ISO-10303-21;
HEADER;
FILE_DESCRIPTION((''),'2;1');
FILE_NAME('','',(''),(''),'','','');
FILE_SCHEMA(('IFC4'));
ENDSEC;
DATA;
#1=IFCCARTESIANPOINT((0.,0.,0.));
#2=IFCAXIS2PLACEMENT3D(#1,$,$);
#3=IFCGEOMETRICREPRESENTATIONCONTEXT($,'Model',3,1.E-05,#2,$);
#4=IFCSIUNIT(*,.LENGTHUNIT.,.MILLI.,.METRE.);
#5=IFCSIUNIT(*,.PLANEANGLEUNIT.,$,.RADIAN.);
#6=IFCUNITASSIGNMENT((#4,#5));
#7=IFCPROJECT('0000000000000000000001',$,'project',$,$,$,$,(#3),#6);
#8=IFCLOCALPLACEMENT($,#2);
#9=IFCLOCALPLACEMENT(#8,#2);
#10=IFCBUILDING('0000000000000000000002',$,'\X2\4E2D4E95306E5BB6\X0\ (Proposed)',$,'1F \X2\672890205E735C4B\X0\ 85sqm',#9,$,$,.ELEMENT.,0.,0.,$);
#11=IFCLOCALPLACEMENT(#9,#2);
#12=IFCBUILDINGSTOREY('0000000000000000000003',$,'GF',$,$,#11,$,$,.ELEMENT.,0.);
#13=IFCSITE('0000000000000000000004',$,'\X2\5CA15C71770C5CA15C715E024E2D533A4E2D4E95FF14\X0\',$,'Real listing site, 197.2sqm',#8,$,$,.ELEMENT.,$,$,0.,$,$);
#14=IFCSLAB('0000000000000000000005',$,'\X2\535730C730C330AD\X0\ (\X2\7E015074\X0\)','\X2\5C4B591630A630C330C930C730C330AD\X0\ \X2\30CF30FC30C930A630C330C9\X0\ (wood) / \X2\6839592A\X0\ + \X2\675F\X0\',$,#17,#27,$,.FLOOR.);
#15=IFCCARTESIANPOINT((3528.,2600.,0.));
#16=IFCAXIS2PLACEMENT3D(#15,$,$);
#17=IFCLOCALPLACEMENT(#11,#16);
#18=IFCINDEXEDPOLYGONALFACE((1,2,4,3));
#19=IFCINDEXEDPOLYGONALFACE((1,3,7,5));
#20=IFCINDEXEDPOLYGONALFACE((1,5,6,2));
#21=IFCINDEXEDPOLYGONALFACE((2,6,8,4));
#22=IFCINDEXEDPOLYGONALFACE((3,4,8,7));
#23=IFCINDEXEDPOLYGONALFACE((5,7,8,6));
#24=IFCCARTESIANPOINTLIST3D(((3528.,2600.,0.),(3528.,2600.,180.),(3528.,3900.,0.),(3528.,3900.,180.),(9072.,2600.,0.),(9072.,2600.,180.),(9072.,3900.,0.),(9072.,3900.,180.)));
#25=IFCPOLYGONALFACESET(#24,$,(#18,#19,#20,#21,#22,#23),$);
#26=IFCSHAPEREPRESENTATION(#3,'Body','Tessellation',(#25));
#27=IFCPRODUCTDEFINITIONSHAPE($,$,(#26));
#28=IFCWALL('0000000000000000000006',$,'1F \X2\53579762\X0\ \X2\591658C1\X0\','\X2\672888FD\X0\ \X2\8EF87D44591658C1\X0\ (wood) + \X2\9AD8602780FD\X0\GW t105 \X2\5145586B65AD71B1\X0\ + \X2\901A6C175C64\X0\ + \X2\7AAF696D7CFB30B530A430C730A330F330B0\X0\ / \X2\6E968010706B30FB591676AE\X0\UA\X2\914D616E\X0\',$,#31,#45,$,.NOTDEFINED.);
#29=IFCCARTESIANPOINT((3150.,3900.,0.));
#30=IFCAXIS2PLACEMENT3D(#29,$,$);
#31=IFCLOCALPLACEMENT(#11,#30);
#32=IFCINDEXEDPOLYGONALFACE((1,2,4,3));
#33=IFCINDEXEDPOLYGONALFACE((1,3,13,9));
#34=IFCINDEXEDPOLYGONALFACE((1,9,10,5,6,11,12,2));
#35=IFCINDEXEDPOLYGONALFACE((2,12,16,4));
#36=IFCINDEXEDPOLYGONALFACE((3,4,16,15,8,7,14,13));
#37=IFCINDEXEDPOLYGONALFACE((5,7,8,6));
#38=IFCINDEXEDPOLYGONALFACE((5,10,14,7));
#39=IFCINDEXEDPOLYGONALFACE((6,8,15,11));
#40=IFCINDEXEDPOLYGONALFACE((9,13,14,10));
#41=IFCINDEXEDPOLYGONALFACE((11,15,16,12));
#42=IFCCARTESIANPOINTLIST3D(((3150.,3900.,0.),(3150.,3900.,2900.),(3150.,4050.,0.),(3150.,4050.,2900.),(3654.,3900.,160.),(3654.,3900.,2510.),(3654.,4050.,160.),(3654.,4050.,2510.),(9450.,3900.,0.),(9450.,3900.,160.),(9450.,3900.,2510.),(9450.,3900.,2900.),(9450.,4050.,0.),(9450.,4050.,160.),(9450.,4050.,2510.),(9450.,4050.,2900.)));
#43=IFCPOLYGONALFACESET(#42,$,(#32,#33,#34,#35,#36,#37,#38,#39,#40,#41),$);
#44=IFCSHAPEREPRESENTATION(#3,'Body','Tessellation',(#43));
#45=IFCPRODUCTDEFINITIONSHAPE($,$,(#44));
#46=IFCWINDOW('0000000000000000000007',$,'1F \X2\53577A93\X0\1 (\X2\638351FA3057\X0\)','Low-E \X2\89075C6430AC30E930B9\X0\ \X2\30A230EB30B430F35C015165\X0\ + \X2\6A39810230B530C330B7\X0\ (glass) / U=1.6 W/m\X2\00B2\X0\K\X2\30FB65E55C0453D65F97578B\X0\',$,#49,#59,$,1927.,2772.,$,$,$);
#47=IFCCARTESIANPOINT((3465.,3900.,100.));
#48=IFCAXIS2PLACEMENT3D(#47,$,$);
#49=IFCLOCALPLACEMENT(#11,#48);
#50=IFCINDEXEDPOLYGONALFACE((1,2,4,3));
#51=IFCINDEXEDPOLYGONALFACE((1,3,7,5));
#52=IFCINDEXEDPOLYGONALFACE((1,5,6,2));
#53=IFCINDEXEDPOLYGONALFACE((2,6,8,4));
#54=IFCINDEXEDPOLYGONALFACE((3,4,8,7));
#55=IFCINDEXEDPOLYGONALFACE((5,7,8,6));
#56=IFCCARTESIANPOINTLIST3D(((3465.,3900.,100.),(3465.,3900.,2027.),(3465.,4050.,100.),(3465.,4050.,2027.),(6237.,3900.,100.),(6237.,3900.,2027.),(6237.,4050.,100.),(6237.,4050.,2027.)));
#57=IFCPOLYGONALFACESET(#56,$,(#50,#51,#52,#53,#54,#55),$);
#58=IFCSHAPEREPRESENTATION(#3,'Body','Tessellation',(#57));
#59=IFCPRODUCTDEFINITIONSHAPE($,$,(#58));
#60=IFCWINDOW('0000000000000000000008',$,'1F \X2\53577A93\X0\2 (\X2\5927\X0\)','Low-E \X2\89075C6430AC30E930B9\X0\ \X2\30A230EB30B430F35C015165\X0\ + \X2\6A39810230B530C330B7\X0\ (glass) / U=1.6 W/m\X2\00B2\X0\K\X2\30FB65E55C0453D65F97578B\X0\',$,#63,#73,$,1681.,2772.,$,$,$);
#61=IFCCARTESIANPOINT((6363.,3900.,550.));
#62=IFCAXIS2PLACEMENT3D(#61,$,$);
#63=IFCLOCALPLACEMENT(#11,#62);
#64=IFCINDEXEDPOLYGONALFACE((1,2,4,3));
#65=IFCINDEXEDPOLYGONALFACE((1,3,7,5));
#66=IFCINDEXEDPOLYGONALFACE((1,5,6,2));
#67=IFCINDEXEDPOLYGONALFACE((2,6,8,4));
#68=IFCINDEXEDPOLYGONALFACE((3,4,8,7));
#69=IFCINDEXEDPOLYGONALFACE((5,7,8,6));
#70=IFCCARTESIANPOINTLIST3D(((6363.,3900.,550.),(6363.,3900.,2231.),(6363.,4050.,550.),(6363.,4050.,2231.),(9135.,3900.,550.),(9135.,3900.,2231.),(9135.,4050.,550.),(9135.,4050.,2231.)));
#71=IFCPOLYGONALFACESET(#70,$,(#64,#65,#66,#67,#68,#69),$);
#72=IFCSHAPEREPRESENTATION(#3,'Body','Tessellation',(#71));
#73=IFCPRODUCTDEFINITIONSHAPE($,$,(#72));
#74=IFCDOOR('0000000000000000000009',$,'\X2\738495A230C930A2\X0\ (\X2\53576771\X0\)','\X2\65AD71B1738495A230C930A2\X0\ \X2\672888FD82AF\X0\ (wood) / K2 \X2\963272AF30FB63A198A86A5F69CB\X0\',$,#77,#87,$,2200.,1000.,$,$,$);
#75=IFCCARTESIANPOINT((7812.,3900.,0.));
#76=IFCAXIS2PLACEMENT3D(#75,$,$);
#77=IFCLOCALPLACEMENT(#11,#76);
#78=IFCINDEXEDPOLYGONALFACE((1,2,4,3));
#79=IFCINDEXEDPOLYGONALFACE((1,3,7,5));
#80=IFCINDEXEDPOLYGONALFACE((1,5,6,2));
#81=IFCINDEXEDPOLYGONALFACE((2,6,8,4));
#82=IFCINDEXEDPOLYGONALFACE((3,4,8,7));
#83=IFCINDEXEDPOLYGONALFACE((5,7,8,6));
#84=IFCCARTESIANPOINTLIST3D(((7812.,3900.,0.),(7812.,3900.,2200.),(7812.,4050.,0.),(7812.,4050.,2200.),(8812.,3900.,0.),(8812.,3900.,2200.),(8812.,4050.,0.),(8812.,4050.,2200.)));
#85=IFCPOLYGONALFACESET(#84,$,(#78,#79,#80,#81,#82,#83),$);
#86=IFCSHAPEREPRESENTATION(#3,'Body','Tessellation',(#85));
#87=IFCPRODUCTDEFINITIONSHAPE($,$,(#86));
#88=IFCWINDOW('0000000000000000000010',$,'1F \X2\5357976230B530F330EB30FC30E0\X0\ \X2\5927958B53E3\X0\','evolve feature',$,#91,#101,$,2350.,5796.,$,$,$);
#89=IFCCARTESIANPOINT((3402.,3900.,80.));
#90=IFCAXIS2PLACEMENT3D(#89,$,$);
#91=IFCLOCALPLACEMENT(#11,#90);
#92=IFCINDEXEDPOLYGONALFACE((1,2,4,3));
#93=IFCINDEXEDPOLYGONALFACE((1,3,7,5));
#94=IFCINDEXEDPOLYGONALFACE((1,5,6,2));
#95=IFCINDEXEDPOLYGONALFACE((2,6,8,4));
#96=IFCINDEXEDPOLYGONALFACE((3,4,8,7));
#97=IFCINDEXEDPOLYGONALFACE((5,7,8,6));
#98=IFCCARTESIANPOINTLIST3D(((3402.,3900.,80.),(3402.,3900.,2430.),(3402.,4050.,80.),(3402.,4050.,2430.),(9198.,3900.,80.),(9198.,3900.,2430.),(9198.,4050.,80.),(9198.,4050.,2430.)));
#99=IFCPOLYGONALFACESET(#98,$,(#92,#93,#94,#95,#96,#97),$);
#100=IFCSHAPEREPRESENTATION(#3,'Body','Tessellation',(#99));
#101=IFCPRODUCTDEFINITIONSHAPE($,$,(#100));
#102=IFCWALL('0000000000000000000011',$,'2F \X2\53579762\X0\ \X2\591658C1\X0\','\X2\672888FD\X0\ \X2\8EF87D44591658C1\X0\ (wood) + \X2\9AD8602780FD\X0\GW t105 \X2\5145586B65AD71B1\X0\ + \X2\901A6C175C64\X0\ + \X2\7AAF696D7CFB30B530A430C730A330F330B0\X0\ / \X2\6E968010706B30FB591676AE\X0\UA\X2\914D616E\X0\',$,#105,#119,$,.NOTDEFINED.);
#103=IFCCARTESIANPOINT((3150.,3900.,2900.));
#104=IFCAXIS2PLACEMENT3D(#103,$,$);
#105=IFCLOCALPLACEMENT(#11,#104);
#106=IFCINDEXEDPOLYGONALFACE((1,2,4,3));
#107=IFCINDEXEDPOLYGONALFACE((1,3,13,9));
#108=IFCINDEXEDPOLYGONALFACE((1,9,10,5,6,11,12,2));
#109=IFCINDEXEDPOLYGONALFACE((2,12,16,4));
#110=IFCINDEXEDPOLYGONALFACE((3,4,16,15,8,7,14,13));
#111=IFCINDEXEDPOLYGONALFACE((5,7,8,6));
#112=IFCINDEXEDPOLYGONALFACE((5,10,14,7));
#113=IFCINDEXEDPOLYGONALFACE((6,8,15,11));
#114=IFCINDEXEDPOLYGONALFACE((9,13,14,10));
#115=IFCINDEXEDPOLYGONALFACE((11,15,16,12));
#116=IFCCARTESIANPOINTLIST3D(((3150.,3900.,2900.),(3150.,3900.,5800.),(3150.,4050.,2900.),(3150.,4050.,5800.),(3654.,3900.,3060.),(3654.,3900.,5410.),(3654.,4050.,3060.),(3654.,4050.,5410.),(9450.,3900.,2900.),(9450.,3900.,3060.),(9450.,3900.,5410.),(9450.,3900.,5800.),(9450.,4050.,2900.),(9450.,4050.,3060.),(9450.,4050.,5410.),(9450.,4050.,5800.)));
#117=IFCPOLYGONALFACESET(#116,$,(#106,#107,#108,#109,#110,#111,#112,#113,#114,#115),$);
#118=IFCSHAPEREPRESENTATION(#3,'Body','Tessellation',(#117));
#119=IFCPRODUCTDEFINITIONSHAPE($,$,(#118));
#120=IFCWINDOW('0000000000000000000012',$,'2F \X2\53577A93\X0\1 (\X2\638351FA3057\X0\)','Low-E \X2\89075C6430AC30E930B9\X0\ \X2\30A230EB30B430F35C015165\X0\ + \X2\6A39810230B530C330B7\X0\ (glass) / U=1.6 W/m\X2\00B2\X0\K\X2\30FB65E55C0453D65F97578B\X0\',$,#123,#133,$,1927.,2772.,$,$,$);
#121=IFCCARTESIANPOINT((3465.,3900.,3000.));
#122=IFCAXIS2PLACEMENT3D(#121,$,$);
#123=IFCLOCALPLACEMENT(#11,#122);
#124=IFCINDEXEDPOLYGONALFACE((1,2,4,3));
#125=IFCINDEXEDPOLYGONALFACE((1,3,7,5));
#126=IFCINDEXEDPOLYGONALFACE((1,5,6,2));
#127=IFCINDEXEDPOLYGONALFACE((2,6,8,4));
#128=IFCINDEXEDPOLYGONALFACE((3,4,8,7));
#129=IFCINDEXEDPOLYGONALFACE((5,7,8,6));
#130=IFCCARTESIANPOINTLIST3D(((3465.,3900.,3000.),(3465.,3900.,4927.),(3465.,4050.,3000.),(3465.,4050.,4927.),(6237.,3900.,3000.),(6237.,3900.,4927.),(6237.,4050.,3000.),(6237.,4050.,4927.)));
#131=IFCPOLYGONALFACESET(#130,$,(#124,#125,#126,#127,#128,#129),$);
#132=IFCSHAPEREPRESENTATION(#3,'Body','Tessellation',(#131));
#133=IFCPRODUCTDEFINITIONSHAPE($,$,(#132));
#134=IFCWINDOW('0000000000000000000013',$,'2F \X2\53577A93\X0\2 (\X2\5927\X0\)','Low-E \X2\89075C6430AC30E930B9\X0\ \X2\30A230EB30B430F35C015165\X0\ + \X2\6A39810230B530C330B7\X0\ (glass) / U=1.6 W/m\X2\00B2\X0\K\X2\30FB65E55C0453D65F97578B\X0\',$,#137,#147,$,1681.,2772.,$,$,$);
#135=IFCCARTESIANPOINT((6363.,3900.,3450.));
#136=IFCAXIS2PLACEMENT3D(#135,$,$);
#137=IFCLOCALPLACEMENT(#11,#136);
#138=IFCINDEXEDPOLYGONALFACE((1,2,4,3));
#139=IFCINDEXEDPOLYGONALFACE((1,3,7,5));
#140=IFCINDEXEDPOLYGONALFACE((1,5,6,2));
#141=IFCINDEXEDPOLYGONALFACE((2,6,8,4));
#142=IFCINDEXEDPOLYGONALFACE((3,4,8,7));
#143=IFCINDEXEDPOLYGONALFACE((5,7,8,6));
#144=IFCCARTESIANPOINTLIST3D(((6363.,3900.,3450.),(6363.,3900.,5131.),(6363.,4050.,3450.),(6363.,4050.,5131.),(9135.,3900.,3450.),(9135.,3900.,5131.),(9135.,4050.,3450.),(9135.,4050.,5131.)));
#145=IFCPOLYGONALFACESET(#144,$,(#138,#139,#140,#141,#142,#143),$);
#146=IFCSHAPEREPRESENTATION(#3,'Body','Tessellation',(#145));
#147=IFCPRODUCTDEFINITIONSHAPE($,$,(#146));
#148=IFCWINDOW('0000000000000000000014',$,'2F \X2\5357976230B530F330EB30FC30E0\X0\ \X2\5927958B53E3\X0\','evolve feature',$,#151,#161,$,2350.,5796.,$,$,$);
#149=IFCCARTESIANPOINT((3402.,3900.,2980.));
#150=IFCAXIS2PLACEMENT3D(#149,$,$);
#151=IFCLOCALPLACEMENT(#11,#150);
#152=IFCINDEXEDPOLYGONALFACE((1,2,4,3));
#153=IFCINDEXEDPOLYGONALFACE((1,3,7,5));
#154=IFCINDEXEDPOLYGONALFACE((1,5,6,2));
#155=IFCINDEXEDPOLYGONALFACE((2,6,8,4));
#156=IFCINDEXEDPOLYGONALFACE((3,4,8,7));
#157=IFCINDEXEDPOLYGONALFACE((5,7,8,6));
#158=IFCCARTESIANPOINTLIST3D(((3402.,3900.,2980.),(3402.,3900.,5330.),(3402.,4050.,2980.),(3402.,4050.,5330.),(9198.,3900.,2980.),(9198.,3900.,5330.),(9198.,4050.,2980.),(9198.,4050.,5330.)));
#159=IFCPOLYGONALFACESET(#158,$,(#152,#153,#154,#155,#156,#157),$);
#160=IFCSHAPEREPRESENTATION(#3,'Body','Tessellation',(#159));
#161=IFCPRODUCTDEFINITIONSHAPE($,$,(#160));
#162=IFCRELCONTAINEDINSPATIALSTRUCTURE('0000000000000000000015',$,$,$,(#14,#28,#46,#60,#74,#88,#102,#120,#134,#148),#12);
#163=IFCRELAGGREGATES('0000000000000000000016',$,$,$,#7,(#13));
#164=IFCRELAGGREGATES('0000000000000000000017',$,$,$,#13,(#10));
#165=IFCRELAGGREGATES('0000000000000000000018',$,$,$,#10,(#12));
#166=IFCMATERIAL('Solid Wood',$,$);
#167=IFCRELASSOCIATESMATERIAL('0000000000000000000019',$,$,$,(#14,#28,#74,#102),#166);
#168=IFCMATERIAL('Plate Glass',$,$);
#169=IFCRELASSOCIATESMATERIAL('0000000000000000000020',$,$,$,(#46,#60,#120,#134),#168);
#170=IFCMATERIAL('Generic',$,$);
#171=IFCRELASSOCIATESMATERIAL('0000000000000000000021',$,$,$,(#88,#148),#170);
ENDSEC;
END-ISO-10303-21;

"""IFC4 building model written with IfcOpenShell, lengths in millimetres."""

from ifc_helpers import new_model, si_unit, frame, frame_2d, origin, place, context, project, spatial, rectangle, extrude, material, element, fill, save


model = new_model("IFC4")

# Units and contexts
model_context = context("Model", 3, precision=1e-05, world=origin())
ifc_project = project(units=[si_unit("LENGTHUNIT", "METRE", prefix="MILLI"), si_unit("PLANEANGLEUNIT", "RADIAN")], contexts=[model_context])

# Site, building, storey
site_placement = place(None, origin())
site = spatial("IfcSite", under=ifc_project, at=site_placement, Name="岡山県岡山市中区中井４", ObjectType="Real listing site, 197.2sqm", CompositionType="ELEMENT", RefElevation=0.0)
building_placement = place(site_placement, origin())
building = spatial("IfcBuilding", under=site, at=building_placement, Name="中井の家 (Proposed)", ObjectType="1F 木造平屋 85sqm", CompositionType="ELEMENT", ElevationOfRefHeight=0.0, ElevationOfTerrain=0.0)
storey_placement = place(building_placement, origin())
storey = spatial("IfcBuildingStorey", under=building, at=storey_placement, Name="GF", CompositionType="ELEMENT", Elevation=0.0)

# Slab
ifc_material_1 = material(Name="Solid Wood")
slab_1_placement = place(storey_placement, frame((3528.0, 2600.0, 0.0)))
element("IfcSlab", 1, at=slab_1_placement, inside=storey, material=ifc_material_1, Name="南デッキ (縁側)", Description="屋外ウッドデッキ ハードウッド (wood) / 根太 + 束", PredefinedType="FLOOR", context=model_context, shape_type="SweptSolid", body=[
    extrude(rectangle(XDim=5544.0, YDim=1300.0, at=frame_2d((2772.0, 650.0))), frame((3528.0, 2600.0, 0.0)), (0.0, 0.0, 1.0), 180.0),
])
ifc_material_2 = material(Name="Generic")

# Wall, openings, windows, door
wall_1_placement = place(storey_placement, frame((3150.0, 3900.0, 0.0)))
wall_1 = element("IfcWall", 2, at=wall_1_placement, inside=storey, material=ifc_material_1, Name="1F 南面 外壁", Description="木製 軸組外壁 (wood) + 高性能GW t105 充填断熱 + 通気層 + 窯業系サイディング / 準耐火・外皮UA配慮", PredefinedType="NOTDEFINED", context=model_context, shape_type="SweptSolid", body=[
    extrude(rectangle(XDim=6300.0, YDim=150.0, at=frame_2d((3150.0, 75.0))), frame((3150.0, 3900.0, 0.0)), (0.0, 0.0, 1.0), 2900.0),
])
opening_1_placement = place(storey_placement, frame((3465.0, 3900.0, 100.0)))
opening_1 = element("IfcOpeningElement", 3, at=opening_1_placement, cuts=wall_1, PredefinedType="NOTDEFINED", context=model_context, shape_type="SweptSolid", body=[
    extrude(rectangle(XDim=2772.0, YDim=150.0, at=frame_2d((1386.0, 75.0))), frame((3465.0, 3900.0, 100.0)), (0.0, 0.0, 1.0), 1927.0),
])
opening_2_placement = place(storey_placement, frame((6363.0, 3900.0, 550.0)))
opening_2 = element("IfcOpeningElement", 4, at=opening_2_placement, cuts=wall_1, PredefinedType="NOTDEFINED", context=model_context, shape_type="SweptSolid", body=[
    extrude(rectangle(XDim=2772.0, YDim=150.0, at=frame_2d((1386.0, 75.0))), frame((6363.0, 3900.0, 550.0)), (0.0, 0.0, 1.0), 1681.0),
])
opening_3_placement = place(storey_placement, frame((7812.0, 3900.0, 0.0)))
opening_3 = element("IfcOpeningElement", 5, at=opening_3_placement, cuts=wall_1, PredefinedType="NOTDEFINED", context=model_context, shape_type="SweptSolid", body=[
    extrude(rectangle(XDim=1000.0, YDim=150.0, at=frame_2d((500.0, 75.0))), frame((7812.0, 3900.0, 0.0)), (0.0, 0.0, 1.0), 2200.0),
])
opening_4_placement = place(storey_placement, frame((3402.0, 3900.0, 80.0)))
opening_4 = element("IfcOpeningElement", 6, at=opening_4_placement, cuts=wall_1, PredefinedType="NOTDEFINED", context=model_context, shape_type="SweptSolid", body=[
    extrude(rectangle(XDim=5796.0, YDim=150.0, at=frame_2d((2898.0, 75.0))), frame((3402.0, 3900.0, 80.0)), (0.0, 0.0, 1.0), 2350.0),
])
ifc_material_3 = material(Name="Plate Glass")
window_1_placement = place(storey_placement, frame((3465.0, 3900.0, 100.0)))
window_1 = element("IfcWindow", 7, at=window_1_placement, inside=storey, material=ifc_material_3, Name="1F 南窓1 (掃出し)", Description="Low-E 複層ガラス アルゴン封入 + 樹脂サッシ (glass) / U=1.6 W/m²K・日射取得型", OverallHeight=1927.0, OverallWidth=2772.0, context=model_context, shape_type="SweptSolid", body=[
    extrude(rectangle(XDim=2772.0, YDim=150.0, at=frame_2d((1386.0, 75.0))), frame((3465.0, 3900.0, 100.0)), (0.0, 0.0, 1.0), 1927.0),
])
fill(opening_1, window_1)
window_2_placement = place(storey_placement, frame((6363.0, 3900.0, 550.0)))
window_2 = element("IfcWindow", 8, at=window_2_placement, inside=storey, material=ifc_material_3, Name="1F 南窓2 (大)", Description="Low-E 複層ガラス アルゴン封入 + 樹脂サッシ (glass) / U=1.6 W/m²K・日射取得型", OverallHeight=1681.0, OverallWidth=2772.0, context=model_context, shape_type="SweptSolid", body=[
    extrude(rectangle(XDim=2772.0, YDim=150.0, at=frame_2d((1386.0, 75.0))), frame((6363.0, 3900.0, 550.0)), (0.0, 0.0, 1.0), 1681.0),
])
fill(opening_2, window_2)
door_placement = place(storey_placement, frame((7812.0, 3900.0, 0.0)))
door = element("IfcDoor", 9, at=door_placement, inside=storey, material=ifc_material_1, Name="玄関ドア (南東)", Description="断熱玄関ドア 木製芯 (wood) / K2 防犯・採風機構", OverallHeight=2200.0, OverallWidth=1000.0, context=model_context, shape_type="SweptSolid", body=[
    extrude(rectangle(XDim=1000.0, YDim=150.0, at=frame_2d((500.0, 75.0))), frame((7812.0, 3900.0, 0.0)), (0.0, 0.0, 1.0), 2200.0),
])
fill(opening_3, door)
window_3_placement = place(storey_placement, frame((3402.0, 3900.0, 80.0)))
window_3 = element("IfcWindow", 10, at=window_3_placement, inside=storey, material=ifc_material_2, Name="1F 南面サンルーム 大開口", Description="evolve feature", OverallHeight=2350.0, OverallWidth=5796.0, context=model_context, shape_type="SweptSolid", body=[
    extrude(rectangle(XDim=5796.0, YDim=150.0, at=frame_2d((2898.0, 75.0))), frame((3402.0, 3900.0, 80.0)), (0.0, 0.0, 1.0), 2350.0),
])
fill(opening_4, window_3)

# Wall, openings, windows
wall_2_placement = place(storey_placement, frame((3150.0, 3900.0, 2900.0)))
wall_2 = element("IfcWall", 11, at=wall_2_placement, inside=storey, material=ifc_material_1, Name="2F 南面 外壁", Description="木製 軸組外壁 (wood) + 高性能GW t105 充填断熱 + 通気層 + 窯業系サイディング / 準耐火・外皮UA配慮", PredefinedType="NOTDEFINED", context=model_context, shape_type="SweptSolid", body=[
    extrude(rectangle(XDim=6300.0, YDim=150.0, at=frame_2d((3150.0, 75.0))), frame((3150.0, 3900.0, 2900.0)), (0.0, 0.0, 1.0), 2900.0),
])
opening_5_placement = place(storey_placement, frame((3465.0, 3900.0, 3000.0)))
opening_5 = element("IfcOpeningElement", 12, at=opening_5_placement, cuts=wall_2, PredefinedType="NOTDEFINED", context=model_context, shape_type="SweptSolid", body=[
    extrude(rectangle(XDim=2772.0, YDim=150.0, at=frame_2d((1386.0, 75.0))), frame((3465.0, 3900.0, 3000.0)), (0.0, 0.0, 1.0), 1927.0),
])
opening_6_placement = place(storey_placement, frame((6363.0, 3900.0, 3450.0)))
opening_6 = element("IfcOpeningElement", 13, at=opening_6_placement, cuts=wall_2, PredefinedType="NOTDEFINED", context=model_context, shape_type="SweptSolid", body=[
    extrude(rectangle(XDim=2772.0, YDim=150.0, at=frame_2d((1386.0, 75.0))), frame((6363.0, 3900.0, 3450.0)), (0.0, 0.0, 1.0), 1681.0),
])
opening_7_placement = place(storey_placement, frame((3402.0, 3900.0, 2980.0)))
opening_7 = element("IfcOpeningElement", 14, at=opening_7_placement, cuts=wall_2, PredefinedType="NOTDEFINED", context=model_context, shape_type="SweptSolid", body=[
    extrude(rectangle(XDim=5796.0, YDim=150.0, at=frame_2d((2898.0, 75.0))), frame((3402.0, 3900.0, 2980.0)), (0.0, 0.0, 1.0), 2350.0),
])
window_4_placement = place(storey_placement, frame((3465.0, 3900.0, 3000.0)))
window_4 = element("IfcWindow", 15, at=window_4_placement, inside=storey, material=ifc_material_3, Name="2F 南窓1 (掃出し)", Description="Low-E 複層ガラス アルゴン封入 + 樹脂サッシ (glass) / U=1.6 W/m²K・日射取得型", OverallHeight=1927.0, OverallWidth=2772.0, context=model_context, shape_type="SweptSolid", body=[
    extrude(rectangle(XDim=2772.0, YDim=150.0, at=frame_2d((1386.0, 75.0))), frame((3465.0, 3900.0, 3000.0)), (0.0, 0.0, 1.0), 1927.0),
])
fill(opening_5, window_4)
window_5_placement = place(storey_placement, frame((6363.0, 3900.0, 3450.0)))
window_5 = element("IfcWindow", 16, at=window_5_placement, inside=storey, material=ifc_material_3, Name="2F 南窓2 (大)", Description="Low-E 複層ガラス アルゴン封入 + 樹脂サッシ (glass) / U=1.6 W/m²K・日射取得型", OverallHeight=1681.0, OverallWidth=2772.0, context=model_context, shape_type="SweptSolid", body=[
    extrude(rectangle(XDim=2772.0, YDim=150.0, at=frame_2d((1386.0, 75.0))), frame((6363.0, 3900.0, 3450.0)), (0.0, 0.0, 1.0), 1681.0),
])
fill(opening_6, window_5)
window_6_placement = place(storey_placement, frame((3402.0, 3900.0, 2980.0)))
window_6 = element("IfcWindow", 17, at=window_6_placement, inside=storey, material=ifc_material_2, Name="2F 南面サンルーム 大開口", Description="evolve feature", OverallHeight=2350.0, OverallWidth=5796.0, context=model_context, shape_type="SweptSolid", body=[
    extrude(rectangle(XDim=5796.0, YDim=150.0, at=frame_2d((2898.0, 75.0))), frame((3402.0, 3900.0, 2980.0)), (0.0, 0.0, 1.0), 2350.0),
])
fill(opening_7, window_6)

save(model, "model.ifc")
